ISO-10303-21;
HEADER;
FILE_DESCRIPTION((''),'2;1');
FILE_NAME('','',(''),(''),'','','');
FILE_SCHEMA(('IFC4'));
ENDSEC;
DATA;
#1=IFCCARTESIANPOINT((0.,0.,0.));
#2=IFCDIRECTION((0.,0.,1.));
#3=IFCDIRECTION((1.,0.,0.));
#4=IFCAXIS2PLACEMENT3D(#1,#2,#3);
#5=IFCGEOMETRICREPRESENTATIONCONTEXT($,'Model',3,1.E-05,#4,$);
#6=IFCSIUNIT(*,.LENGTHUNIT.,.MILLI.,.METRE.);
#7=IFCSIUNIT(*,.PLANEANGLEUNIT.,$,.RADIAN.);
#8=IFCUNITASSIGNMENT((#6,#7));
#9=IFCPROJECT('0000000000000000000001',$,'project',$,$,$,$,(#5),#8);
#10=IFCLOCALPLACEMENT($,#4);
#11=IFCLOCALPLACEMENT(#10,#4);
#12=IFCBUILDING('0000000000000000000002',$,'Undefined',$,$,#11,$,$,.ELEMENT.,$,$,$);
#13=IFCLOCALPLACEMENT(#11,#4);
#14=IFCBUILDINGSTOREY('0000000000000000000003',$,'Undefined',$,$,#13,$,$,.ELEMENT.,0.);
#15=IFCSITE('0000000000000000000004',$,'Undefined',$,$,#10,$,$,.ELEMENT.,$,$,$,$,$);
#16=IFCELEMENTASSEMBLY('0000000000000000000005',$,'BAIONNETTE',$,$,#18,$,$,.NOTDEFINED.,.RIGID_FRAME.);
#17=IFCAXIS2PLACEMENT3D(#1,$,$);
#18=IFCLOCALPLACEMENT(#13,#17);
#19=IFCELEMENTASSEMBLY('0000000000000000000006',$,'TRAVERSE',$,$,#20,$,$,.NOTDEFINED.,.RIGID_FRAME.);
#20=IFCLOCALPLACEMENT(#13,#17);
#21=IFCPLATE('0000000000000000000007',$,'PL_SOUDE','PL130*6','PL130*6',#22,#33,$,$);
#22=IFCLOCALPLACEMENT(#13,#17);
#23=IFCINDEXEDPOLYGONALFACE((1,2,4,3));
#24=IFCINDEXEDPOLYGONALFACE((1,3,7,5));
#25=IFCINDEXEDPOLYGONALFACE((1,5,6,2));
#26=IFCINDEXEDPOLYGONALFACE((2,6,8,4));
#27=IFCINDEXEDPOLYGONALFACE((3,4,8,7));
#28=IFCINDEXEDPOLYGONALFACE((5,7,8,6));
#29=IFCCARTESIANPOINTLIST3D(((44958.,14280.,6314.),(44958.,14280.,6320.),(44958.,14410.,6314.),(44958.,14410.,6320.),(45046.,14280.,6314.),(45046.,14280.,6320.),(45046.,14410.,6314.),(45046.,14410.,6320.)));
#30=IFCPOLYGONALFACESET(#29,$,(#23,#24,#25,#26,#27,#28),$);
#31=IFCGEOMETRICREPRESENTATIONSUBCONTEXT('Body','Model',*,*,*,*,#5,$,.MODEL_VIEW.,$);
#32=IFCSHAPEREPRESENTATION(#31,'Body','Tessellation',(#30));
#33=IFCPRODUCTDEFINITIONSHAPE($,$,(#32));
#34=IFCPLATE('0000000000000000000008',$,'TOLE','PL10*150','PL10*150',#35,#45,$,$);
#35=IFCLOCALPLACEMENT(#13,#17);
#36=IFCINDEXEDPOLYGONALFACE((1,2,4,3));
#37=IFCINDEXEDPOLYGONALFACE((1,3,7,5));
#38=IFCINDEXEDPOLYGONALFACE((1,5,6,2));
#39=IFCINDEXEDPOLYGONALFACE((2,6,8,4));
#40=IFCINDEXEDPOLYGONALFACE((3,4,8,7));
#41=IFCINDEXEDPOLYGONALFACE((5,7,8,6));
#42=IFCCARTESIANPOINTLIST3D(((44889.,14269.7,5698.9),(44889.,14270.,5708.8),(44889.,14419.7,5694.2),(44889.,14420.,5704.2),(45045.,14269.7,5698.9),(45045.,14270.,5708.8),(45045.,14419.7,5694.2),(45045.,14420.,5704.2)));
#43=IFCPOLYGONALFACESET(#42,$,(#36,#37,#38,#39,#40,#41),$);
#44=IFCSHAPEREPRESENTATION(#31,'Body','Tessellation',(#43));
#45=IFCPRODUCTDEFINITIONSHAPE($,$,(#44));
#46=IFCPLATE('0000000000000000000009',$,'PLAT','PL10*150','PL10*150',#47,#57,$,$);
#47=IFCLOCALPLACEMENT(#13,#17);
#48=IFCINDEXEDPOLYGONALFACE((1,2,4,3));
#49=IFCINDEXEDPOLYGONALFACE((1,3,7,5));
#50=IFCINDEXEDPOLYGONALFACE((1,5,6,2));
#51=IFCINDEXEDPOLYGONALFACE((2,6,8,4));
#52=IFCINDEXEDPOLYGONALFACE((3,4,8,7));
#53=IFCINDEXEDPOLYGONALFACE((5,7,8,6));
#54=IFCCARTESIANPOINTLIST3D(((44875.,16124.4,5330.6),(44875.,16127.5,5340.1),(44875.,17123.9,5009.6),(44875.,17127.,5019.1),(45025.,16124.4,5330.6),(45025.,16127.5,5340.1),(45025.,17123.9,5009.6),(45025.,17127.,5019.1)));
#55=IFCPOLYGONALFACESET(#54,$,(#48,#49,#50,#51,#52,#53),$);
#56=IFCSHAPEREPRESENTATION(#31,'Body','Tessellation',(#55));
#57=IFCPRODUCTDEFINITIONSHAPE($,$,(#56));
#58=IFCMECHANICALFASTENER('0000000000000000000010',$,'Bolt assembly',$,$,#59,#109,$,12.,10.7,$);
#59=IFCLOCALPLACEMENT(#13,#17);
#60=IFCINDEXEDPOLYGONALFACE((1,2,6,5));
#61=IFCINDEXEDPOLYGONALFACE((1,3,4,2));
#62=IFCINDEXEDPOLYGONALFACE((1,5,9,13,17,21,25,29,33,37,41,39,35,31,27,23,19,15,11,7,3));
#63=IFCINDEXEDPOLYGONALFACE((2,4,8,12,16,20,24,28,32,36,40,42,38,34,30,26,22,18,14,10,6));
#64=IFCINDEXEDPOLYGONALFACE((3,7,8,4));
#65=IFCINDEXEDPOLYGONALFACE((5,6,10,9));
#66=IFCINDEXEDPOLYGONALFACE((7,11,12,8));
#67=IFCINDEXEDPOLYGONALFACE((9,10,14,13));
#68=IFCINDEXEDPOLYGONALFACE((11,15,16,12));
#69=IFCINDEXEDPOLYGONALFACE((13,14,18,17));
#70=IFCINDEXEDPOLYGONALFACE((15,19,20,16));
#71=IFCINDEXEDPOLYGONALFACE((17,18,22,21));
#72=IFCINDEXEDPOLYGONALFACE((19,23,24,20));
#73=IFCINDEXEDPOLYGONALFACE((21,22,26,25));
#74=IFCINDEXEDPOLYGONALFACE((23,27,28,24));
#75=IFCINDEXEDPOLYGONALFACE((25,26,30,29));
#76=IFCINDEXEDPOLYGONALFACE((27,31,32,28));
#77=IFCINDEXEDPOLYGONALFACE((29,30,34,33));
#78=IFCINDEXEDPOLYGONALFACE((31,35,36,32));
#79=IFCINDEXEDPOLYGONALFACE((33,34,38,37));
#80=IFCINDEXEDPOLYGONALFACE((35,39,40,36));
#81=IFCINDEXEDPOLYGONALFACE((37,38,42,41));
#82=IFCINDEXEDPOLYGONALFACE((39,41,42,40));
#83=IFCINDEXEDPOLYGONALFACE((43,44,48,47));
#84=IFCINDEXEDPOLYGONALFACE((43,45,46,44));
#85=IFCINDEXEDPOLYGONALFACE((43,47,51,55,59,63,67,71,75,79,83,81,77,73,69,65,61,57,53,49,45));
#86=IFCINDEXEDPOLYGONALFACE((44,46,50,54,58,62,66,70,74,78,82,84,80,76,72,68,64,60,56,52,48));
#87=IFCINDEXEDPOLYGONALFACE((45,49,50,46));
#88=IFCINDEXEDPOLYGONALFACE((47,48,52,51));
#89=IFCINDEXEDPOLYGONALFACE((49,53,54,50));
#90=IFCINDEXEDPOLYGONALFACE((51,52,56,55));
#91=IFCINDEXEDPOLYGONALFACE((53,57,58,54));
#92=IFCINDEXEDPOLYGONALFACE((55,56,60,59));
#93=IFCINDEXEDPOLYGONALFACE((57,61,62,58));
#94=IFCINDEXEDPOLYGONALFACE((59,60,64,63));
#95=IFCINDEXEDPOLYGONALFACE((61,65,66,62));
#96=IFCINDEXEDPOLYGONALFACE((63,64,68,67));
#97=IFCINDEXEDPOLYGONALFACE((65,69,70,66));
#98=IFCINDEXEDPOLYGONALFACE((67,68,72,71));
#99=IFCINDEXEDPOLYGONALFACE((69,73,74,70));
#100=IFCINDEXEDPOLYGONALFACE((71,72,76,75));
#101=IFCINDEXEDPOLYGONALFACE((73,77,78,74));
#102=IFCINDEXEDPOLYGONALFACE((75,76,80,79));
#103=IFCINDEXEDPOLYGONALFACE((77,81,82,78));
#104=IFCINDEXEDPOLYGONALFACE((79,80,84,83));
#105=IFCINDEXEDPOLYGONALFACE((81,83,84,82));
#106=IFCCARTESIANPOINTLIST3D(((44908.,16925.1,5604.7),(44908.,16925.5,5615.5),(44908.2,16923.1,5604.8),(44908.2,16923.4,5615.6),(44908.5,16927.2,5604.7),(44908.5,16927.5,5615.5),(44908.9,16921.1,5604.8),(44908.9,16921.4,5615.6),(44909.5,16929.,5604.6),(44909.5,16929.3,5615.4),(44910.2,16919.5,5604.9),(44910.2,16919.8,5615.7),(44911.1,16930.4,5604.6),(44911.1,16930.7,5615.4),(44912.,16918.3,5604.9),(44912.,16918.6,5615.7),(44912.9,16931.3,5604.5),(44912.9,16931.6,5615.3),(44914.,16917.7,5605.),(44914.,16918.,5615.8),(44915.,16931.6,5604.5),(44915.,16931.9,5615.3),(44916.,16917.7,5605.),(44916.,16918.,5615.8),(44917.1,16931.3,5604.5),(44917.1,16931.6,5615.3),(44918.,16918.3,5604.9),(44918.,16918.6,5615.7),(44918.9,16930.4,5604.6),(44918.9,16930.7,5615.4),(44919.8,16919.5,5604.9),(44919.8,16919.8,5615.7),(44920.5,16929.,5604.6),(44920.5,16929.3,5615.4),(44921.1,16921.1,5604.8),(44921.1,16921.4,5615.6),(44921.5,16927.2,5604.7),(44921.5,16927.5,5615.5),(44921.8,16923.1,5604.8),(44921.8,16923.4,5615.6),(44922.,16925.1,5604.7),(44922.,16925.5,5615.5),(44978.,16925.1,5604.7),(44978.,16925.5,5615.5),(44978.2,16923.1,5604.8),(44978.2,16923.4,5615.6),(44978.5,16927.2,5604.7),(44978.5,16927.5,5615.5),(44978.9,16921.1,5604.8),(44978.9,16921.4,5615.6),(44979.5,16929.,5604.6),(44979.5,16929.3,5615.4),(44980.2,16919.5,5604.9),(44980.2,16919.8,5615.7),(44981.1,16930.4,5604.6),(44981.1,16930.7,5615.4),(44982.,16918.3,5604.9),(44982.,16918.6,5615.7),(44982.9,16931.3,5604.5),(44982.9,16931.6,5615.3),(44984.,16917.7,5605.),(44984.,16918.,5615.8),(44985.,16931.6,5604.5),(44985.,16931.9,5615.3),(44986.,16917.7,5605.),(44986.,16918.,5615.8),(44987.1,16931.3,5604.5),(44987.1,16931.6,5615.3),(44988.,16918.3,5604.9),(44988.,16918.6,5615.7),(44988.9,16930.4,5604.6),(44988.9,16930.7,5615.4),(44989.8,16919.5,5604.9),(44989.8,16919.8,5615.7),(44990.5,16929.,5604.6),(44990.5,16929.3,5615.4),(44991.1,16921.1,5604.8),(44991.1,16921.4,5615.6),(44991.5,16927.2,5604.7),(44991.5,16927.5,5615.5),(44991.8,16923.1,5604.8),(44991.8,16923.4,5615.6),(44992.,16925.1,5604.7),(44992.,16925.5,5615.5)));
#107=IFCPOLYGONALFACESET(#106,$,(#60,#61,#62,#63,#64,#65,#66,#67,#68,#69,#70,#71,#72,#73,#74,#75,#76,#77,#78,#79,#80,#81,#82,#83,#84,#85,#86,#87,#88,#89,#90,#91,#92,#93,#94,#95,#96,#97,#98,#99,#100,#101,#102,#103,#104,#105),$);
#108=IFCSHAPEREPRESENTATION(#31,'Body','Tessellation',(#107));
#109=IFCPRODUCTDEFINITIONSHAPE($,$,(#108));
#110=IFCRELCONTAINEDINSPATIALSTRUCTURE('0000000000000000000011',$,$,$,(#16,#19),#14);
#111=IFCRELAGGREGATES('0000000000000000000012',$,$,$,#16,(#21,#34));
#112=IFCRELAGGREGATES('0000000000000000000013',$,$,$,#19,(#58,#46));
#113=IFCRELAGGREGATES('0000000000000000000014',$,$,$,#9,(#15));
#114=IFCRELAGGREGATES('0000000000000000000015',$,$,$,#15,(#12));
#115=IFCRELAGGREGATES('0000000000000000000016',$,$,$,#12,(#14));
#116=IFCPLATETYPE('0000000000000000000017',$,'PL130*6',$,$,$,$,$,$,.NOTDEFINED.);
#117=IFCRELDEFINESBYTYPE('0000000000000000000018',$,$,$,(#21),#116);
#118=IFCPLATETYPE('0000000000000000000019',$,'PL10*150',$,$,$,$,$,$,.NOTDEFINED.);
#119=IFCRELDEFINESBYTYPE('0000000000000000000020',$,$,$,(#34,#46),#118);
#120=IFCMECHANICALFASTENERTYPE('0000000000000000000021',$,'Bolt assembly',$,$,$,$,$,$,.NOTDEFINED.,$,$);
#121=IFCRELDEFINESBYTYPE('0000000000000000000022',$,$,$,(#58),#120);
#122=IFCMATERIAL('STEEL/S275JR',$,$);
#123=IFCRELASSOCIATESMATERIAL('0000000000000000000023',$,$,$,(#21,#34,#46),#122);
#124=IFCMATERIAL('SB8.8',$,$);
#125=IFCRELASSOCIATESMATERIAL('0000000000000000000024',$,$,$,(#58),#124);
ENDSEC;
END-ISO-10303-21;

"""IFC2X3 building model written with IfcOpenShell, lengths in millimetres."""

from ifc_helpers import new_model, si_unit, frame, origin_with_axes, origin_2d_with_axis, place, context, subcontext, project, spatial, polyline, circle, outline, extrude, source, transform, mapped, material, type_object, element, aggregate, save


model = new_model("IFC2X3")

# Units and contexts
model_context = context("Model", 3, precision=1e-05, world=origin_with_axes())
body_context = subcontext(model_context, "Body", "Model", "MODEL_VIEW")
ifc_project = project(units=[si_unit("LENGTHUNIT", "METRE", prefix="MILLI"), si_unit("PLANEANGLEUNIT", "RADIAN")], contexts=[model_context])

# Site, building, storey
site_placement = place(None, origin_with_axes())
site = spatial("IfcSite", under=ifc_project, at=site_placement, Name="Undefined", CompositionType="ELEMENT")
building_placement = place(site_placement, origin_with_axes())
building = spatial("IfcBuilding", under=site, at=building_placement, Name="Undefined", CompositionType="ELEMENT")
storey_placement = place(building_placement, origin_with_axes())
storey = spatial("IfcBuildingStorey", under=building, at=storey_placement, Name="Undefined", CompositionType="ELEMENT", Elevation=0.0)

# Shared definitions
ifc_material_1 = material(Name="STEEL/S275JR")

# Element assembly
assembly_1_placement = place(storey_placement, origin_with_axes())
assembly_1 = element("IfcElementAssembly", 1, at=assembly_1_placement, inside=storey, Name="BAIONNETTE", AssemblyPlace="NOTDEFINED", PredefinedType="RIGID_FRAME")

# Element assembly
assembly_2_placement = place(storey_placement, origin_with_axes())
assembly_2 = element("IfcElementAssembly", 2, at=assembly_2_placement, inside=storey, Name="TRAVERSE", AssemblyPlace="NOTDEFINED", PredefinedType="RIGID_FRAME")

# Plates
plate_type_1 = type_object("IfcPlateType", Name="PL130*6", PredefinedType="NOTDEFINED")
plate_1_placement = place(assembly_1_placement, frame((45046.0, 14345.0, 6317.0), z_axis=(0.0, 0.0, 1.0), x_axis=(-1.0, 0.0, 0.0)))
plate_1 = element("IfcPlate", 3, at=plate_1_placement, type_object=plate_type_1, material=ifc_material_1, Name="PL_SOUDE", Description="PL130*6", ObjectType="PL130*6", context=body_context, shape_type="SweptSolid", body=[
    extrude(outline(polyline([(88.0, 65.0), (88.0, -65.0), (0.0, -65.0), (0.0, 65.0), (88.0, 65.0)])), frame((0.0, 0.0, -3.0), z_axis=(0.0, 0.0, 1.0), x_axis=(1.0, 0.0, 0.0)), (0.0, 0.0, 1.0), 6.0),
])
plate_type_2 = type_object("IfcPlateType", Name="PL10*150", PredefinedType="NOTDEFINED")
plate_2_placement = place(assembly_1_placement, frame((45045.0, 14344.8, 5701.5), z_axis=(0.0, -0.030986, -0.99952), x_axis=(-1.0, 0.0, 0.0)))
plate_2 = element("IfcPlate", 4, at=plate_2_placement, type_object=plate_type_2, material=ifc_material_1, Name="TOLE", Description="PL10*150", ObjectType="PL10*150", context=body_context, shape_type="SweptSolid", body=[
    extrude(outline(polyline([(156.0, -75.0), (0.0, -75.0), (0.0, 75.0), (156.0, 75.0), (156.0, -75.0)])), frame((0.0, 0.0, -5.0), z_axis=(0.0, 0.0, 1.0), x_axis=(1.0, 0.0, 0.0)), (0.0, 0.0, 1.0), 10.0),
])
plate_3_placement = place(assembly_2_placement, frame((44950.0, 17125.5, 5014.4), z_axis=(0.0, -0.30576, -0.952109), x_axis=(0.0, -0.952109, 0.30576)))
plate_3 = element("IfcPlate", 5, at=plate_3_placement, type_object=plate_type_2, material=ifc_material_1, Name="PLAT", Description="PL10*150", ObjectType="PL10*150", context=body_context, shape_type="SweptSolid", body=[
    extrude(outline(polyline([(1049.8, 75.0), (1049.8, -75.0), (0.0, -75.0), (0.0, 75.0), (1049.8, 75.0)])), frame((0.0, 0.0, -5.0), z_axis=(0.0, 0.0, 1.0), x_axis=(1.0, 0.0, 0.0)), (0.0, 0.0, 1.0), 10.0),
])

# Mechanical fastener
ifc_material_2 = material(Name="SB8.8")
mechanical_fastener_type = type_object("IfcMechanicalFastenerType", Name="Bolt assembly")
shared_shape_1 = source(origin_with_axes(), body_context, "Body", "SweptSolid", [
    extrude(circle(Radius=7.0, at=origin_2d_with_axis()), frame((0.0, 0.0, 0.0), z_axis=(0.0, 1.0, 0.0), x_axis=(1.0, 0.0, 0.0)), (0.0, 0.0, 1.0), 10.8),
])
mechanical_fastener_1_placement = place(assembly_2_placement, frame((44950.0, 16924.9, 5615.5), z_axis=(-1.0, 0.0, 0.0), x_axis=(0.0, 0.99952, -0.030986)))
mechanical_fastener_1 = element("IfcMechanicalFastener", 6, at=mechanical_fastener_1_placement, type_object=mechanical_fastener_type, material=ifc_material_2, Name="Bolt assembly", NominalDiameter=12.0, NominalLength=10.7, context=body_context, shape_type="MappedRepresentation", body=[
    mapped(shared_shape_1, transform((0.0, 0.0, 35.0))),
    mapped(shared_shape_1, transform((0.0, 0.0, -35.0))),
])

aggregate(assembly_1, [plate_1, plate_2])

aggregate(assembly_2, [mechanical_fastener_1, plate_3])

save(model, "model.ifc")
